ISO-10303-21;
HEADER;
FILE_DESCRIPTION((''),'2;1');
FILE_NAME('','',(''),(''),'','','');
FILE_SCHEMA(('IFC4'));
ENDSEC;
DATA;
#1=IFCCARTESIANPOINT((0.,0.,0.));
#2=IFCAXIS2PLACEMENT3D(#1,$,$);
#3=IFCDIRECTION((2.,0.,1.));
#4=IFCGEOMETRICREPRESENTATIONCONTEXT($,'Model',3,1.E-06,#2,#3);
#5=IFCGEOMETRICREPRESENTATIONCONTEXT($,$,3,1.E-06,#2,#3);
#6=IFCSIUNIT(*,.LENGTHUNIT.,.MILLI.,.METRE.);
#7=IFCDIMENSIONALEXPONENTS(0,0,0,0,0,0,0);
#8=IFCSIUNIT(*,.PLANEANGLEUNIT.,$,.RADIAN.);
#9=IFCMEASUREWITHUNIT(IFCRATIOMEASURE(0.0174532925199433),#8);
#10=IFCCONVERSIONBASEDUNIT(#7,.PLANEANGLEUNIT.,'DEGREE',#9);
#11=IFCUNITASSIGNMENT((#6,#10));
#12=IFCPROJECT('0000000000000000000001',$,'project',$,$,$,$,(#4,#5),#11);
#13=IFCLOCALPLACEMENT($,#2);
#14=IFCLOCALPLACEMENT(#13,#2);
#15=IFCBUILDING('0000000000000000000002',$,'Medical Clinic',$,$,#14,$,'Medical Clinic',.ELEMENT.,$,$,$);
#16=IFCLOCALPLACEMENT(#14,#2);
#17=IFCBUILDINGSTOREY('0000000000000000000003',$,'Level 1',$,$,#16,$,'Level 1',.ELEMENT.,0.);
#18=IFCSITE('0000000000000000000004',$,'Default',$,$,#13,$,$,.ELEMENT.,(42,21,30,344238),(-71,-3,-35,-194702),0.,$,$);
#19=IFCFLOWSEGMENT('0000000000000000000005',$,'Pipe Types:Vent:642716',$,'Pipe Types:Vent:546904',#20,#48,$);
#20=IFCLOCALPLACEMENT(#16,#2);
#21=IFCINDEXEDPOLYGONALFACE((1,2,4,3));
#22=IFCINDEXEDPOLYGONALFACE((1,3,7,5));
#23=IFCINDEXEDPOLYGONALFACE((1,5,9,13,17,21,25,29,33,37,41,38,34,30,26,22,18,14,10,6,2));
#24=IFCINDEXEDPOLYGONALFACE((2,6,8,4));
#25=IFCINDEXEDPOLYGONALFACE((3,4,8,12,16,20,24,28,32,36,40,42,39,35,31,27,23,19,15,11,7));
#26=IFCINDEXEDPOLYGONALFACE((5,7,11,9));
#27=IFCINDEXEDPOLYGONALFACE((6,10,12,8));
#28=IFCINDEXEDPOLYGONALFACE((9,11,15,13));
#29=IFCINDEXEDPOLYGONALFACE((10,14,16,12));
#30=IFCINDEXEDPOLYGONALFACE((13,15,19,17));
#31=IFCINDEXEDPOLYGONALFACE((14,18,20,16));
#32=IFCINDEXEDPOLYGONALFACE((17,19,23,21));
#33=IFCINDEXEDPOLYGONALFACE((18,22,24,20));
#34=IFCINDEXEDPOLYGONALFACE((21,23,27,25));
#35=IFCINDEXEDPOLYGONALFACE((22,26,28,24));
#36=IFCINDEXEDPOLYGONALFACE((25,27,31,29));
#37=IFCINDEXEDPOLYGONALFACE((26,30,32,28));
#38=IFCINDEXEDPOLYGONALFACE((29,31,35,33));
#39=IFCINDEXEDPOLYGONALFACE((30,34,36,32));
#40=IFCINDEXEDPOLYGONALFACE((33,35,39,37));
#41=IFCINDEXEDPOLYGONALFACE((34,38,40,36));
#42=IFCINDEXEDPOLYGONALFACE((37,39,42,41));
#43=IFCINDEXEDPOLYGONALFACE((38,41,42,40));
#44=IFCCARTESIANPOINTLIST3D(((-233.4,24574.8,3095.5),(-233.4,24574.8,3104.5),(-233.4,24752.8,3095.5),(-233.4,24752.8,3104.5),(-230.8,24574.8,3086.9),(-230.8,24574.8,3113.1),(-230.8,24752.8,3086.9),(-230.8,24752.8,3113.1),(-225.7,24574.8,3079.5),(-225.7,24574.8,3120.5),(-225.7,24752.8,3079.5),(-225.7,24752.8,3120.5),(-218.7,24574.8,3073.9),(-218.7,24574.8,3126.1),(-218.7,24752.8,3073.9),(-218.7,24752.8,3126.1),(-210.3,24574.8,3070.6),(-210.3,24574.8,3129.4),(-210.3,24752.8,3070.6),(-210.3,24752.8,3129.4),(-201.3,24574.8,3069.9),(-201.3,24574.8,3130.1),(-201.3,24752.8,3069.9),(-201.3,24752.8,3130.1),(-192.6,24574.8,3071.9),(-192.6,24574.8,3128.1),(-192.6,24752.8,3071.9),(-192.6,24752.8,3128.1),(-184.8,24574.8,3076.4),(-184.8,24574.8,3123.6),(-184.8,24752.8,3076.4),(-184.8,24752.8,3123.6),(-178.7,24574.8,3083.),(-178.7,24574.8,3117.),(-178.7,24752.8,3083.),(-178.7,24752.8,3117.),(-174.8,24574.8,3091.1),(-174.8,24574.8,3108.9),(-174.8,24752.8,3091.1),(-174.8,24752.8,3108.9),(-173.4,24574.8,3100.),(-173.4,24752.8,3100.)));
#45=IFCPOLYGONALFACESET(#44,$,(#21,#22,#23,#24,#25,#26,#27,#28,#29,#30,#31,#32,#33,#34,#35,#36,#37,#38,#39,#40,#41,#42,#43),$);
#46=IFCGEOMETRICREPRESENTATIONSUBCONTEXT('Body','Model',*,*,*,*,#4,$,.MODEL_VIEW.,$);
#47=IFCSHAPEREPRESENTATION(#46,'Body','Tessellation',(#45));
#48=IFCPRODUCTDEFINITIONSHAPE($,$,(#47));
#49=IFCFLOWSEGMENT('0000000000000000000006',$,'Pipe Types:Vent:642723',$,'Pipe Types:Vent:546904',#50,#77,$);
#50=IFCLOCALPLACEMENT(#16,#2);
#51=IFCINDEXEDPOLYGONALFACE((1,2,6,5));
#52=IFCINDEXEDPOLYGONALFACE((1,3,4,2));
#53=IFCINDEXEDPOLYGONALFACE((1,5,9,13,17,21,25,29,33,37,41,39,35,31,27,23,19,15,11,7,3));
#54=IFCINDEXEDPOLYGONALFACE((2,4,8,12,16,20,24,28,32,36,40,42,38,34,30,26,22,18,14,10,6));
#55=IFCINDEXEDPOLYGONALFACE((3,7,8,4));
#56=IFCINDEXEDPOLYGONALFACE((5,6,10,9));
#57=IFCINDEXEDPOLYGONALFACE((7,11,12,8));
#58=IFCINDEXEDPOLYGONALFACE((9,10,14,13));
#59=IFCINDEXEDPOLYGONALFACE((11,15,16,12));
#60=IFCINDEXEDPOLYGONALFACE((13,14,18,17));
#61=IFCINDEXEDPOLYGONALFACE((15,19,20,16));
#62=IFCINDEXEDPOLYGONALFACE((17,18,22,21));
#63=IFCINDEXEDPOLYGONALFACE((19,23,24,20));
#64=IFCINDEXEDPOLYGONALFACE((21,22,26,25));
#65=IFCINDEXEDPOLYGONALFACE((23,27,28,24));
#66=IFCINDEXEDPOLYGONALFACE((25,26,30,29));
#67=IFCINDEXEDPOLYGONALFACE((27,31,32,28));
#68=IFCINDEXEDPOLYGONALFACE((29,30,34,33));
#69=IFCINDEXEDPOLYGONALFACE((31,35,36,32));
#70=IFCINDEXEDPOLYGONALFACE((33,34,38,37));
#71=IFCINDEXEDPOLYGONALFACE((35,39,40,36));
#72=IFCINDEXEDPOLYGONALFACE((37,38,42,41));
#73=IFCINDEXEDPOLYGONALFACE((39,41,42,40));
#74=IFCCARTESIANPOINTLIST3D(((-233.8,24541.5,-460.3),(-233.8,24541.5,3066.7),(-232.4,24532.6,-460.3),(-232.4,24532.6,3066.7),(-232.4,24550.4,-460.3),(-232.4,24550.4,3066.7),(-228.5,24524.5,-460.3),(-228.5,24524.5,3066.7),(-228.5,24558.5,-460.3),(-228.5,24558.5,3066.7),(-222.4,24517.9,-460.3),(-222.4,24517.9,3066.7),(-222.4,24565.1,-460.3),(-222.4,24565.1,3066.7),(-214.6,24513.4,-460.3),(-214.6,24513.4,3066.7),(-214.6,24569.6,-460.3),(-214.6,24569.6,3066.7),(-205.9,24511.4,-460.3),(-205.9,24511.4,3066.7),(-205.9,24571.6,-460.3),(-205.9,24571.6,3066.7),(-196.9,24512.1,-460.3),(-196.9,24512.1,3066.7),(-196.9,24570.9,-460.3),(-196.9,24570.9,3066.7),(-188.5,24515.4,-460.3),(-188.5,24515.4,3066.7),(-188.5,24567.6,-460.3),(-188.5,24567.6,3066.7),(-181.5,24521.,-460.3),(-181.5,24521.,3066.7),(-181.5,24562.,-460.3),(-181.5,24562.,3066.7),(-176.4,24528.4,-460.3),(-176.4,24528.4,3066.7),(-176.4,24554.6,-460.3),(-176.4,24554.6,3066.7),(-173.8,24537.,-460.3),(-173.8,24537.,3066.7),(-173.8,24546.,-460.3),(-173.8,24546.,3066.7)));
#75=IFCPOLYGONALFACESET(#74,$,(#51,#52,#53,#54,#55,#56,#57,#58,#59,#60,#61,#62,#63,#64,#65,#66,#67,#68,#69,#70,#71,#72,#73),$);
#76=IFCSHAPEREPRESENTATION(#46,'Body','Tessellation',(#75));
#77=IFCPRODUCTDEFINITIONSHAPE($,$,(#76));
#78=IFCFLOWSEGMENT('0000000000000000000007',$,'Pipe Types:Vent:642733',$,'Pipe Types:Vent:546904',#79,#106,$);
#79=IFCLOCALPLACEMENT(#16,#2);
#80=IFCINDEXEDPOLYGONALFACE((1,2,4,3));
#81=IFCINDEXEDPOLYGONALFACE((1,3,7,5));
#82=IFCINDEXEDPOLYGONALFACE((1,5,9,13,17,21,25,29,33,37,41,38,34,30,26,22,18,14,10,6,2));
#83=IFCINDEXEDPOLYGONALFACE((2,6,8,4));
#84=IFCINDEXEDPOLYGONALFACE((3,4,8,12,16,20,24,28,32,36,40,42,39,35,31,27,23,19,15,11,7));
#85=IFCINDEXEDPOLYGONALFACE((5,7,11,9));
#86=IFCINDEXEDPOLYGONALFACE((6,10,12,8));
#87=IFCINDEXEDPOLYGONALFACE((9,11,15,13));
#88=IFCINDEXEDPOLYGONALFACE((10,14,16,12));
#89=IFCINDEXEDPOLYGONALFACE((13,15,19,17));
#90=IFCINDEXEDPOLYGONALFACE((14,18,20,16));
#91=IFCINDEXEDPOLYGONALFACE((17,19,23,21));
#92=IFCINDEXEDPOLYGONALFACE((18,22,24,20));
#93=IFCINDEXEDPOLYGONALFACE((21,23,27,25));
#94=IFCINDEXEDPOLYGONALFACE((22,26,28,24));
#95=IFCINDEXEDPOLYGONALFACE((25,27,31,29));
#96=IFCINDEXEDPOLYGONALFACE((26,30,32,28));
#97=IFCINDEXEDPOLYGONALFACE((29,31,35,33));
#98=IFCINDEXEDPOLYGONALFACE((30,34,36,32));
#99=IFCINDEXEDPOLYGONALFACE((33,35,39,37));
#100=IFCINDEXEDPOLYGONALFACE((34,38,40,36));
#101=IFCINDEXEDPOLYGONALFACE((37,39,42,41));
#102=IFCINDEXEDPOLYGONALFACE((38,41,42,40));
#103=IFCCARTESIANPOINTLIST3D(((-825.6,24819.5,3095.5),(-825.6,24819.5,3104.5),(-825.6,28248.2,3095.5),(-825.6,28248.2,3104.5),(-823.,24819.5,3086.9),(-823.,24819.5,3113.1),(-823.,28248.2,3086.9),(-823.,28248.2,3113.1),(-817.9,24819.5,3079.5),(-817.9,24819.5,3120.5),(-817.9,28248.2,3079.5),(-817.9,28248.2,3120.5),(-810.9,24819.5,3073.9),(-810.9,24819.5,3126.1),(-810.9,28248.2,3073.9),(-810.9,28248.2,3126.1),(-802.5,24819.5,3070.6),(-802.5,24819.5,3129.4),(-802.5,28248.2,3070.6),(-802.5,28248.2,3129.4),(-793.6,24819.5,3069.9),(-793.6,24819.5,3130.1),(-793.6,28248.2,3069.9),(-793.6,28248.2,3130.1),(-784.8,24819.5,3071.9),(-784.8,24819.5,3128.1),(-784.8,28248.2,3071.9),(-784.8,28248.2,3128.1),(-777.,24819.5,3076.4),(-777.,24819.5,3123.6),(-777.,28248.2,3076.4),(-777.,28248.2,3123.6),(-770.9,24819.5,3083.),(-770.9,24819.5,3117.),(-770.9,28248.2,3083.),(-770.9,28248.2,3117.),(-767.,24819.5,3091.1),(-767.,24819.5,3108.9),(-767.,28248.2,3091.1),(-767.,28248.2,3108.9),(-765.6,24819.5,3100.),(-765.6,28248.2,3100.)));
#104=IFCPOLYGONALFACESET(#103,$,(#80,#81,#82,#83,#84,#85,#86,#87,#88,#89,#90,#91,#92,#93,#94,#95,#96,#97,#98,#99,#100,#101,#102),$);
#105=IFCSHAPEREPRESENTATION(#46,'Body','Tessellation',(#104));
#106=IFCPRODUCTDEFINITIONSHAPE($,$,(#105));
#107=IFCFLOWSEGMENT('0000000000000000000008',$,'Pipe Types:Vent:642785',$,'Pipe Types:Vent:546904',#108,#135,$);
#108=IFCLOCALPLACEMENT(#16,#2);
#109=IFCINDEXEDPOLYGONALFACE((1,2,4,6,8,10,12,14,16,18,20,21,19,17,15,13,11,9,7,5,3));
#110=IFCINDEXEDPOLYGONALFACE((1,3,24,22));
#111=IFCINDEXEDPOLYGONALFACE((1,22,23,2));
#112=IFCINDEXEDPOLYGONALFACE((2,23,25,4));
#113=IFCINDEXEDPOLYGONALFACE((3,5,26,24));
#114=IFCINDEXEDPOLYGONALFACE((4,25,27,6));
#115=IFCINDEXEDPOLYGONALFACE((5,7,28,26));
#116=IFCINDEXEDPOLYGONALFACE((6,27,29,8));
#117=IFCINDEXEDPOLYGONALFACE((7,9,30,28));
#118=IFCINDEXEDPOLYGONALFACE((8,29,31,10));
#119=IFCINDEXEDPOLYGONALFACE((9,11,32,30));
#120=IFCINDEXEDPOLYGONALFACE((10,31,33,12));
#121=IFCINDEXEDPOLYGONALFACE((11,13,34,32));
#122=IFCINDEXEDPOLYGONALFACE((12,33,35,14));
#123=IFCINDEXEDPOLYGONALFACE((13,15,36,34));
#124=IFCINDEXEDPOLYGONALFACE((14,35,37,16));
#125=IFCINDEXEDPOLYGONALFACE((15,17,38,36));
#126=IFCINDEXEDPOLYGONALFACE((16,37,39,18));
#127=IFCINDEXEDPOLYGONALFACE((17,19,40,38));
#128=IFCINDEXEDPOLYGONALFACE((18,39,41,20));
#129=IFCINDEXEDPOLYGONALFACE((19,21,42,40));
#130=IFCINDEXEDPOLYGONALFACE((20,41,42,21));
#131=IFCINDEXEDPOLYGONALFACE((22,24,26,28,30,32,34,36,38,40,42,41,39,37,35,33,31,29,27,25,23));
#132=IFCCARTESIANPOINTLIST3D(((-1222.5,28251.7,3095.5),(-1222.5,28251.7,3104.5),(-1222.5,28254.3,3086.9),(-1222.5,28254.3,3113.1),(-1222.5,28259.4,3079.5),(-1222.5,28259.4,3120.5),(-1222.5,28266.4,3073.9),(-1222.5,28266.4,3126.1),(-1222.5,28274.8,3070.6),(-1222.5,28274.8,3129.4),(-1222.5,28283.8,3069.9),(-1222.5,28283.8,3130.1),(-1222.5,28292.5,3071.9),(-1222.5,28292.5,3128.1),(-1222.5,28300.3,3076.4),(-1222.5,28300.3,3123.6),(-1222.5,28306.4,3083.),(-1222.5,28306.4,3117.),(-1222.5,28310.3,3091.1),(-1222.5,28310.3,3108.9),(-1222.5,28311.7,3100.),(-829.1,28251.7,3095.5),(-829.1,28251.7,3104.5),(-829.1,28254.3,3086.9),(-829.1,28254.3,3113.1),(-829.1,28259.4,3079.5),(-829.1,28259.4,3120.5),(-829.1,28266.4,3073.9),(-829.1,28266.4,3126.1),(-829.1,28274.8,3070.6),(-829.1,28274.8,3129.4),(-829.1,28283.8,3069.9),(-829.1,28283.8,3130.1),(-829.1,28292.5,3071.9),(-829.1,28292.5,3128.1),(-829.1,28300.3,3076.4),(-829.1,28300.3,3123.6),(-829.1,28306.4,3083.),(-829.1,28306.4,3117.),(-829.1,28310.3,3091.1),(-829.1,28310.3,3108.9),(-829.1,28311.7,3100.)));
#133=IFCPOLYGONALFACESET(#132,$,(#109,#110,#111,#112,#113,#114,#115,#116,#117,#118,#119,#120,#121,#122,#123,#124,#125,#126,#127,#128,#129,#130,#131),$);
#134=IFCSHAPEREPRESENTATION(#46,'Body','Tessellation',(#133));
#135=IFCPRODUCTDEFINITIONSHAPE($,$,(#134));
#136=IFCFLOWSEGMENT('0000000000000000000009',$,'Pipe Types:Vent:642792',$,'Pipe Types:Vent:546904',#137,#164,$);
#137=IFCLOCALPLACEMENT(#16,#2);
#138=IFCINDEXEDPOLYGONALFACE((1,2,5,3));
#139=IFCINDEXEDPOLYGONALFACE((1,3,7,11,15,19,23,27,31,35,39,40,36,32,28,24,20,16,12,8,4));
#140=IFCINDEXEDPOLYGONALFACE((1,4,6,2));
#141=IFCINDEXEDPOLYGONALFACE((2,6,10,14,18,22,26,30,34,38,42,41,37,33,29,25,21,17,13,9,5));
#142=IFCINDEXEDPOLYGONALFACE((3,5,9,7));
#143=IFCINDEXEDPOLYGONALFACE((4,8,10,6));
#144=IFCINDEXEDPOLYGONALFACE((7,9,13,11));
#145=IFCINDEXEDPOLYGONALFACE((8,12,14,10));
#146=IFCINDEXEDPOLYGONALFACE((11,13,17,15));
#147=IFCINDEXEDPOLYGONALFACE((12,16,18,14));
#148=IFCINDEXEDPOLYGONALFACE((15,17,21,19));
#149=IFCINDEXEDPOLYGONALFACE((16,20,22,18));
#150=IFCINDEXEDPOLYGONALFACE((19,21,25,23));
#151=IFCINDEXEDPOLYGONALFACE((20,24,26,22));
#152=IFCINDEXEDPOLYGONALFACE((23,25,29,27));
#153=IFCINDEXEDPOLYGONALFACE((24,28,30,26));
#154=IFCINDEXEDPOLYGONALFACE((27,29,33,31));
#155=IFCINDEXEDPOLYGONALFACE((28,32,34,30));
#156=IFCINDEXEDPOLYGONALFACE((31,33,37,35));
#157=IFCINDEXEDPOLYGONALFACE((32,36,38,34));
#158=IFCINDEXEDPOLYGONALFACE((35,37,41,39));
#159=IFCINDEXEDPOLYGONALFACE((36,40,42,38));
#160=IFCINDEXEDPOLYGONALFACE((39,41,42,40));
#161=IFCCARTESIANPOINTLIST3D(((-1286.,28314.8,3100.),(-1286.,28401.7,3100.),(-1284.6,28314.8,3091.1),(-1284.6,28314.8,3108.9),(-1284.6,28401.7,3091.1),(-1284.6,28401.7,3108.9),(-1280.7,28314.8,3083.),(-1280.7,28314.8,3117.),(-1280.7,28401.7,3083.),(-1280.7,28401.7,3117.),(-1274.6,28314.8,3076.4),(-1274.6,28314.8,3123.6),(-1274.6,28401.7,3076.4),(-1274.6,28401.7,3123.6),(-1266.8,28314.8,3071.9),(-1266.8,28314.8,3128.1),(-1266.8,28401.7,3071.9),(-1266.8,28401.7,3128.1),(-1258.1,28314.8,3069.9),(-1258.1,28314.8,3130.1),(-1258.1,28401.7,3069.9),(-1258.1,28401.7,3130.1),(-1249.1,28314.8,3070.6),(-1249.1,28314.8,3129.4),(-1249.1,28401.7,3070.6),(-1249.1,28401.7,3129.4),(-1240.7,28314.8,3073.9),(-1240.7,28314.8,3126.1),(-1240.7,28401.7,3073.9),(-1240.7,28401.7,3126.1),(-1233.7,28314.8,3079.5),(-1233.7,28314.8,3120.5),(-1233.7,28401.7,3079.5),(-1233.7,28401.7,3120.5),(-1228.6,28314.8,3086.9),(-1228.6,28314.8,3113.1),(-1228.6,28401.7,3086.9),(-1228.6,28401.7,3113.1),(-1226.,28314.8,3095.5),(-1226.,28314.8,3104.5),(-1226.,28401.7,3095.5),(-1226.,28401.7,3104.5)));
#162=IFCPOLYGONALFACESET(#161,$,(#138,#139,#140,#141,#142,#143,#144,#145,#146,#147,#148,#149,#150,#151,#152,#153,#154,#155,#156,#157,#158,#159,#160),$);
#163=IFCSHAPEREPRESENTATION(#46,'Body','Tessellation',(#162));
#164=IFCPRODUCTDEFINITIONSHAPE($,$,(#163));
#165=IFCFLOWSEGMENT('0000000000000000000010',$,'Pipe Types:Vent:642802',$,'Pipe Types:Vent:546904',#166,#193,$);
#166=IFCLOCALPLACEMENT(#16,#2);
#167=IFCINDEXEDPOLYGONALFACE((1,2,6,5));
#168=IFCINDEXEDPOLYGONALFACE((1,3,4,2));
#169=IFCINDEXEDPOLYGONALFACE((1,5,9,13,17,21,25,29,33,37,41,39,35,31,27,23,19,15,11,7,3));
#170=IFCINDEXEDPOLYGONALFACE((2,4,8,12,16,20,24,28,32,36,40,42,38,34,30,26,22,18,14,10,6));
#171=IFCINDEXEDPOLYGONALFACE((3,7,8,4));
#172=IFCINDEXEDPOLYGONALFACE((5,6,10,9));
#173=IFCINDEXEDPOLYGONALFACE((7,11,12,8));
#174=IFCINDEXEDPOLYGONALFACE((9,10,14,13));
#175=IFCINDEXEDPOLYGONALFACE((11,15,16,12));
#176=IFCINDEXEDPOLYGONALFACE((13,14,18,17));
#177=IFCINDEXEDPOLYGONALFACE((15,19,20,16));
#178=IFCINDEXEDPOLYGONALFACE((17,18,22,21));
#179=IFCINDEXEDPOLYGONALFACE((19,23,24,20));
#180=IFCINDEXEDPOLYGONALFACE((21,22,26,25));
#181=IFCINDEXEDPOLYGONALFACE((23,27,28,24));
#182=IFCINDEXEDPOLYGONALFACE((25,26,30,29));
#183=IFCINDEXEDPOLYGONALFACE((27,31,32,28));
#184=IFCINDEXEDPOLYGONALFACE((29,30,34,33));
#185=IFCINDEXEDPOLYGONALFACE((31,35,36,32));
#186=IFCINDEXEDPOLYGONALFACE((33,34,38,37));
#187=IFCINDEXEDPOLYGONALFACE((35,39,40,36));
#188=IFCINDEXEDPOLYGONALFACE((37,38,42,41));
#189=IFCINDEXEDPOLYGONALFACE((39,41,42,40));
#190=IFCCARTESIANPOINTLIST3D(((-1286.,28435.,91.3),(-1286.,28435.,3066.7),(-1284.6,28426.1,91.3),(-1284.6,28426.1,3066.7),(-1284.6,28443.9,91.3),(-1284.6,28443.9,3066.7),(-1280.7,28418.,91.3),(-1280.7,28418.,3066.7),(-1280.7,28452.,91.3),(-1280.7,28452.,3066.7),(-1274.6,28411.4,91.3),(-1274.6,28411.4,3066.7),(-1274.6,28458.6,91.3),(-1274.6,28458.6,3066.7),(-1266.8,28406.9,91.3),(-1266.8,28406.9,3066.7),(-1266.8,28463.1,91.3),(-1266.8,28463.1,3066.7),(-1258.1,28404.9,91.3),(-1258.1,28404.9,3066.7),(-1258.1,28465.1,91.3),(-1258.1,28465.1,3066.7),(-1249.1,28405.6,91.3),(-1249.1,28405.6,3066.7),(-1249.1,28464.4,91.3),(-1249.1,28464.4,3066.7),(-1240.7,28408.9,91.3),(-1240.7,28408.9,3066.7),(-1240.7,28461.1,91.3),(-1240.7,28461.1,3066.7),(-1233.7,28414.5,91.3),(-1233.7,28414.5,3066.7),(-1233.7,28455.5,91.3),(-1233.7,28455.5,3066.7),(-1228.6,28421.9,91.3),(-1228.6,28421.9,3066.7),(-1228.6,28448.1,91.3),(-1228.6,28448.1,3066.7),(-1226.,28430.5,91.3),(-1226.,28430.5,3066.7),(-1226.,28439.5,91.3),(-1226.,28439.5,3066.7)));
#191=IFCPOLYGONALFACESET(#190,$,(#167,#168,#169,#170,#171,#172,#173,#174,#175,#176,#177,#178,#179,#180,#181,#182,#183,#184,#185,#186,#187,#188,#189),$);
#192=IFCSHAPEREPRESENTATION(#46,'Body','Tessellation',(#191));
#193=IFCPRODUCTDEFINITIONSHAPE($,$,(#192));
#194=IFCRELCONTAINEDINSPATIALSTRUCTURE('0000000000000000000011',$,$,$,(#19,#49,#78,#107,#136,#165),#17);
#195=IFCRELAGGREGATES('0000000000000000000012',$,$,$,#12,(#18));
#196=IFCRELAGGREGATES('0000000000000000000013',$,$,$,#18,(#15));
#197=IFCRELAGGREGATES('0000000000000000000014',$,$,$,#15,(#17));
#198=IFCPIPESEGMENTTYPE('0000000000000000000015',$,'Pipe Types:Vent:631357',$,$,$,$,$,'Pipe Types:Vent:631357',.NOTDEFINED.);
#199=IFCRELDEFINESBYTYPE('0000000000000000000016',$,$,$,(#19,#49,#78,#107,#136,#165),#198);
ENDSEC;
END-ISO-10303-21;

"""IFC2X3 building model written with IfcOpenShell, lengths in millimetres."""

from ifc_helpers import new_model, entity, si_unit, converted_unit, direction, frame, frame_2d, origin, place, context, subcontext, project, spatial, circle, extrude, type_object, element, save


model = new_model("IFC2X3")

# Units and contexts
model_context = context("Model", 3, precision=1e-06, world=origin(), true_north=direction((2.0, 0.0, 1.0)))
context_of_model = context(None, 3, precision=1e-06, world=origin(), true_north=direction((2.0, 0.0, 1.0)))
body_context = subcontext(model_context, "Body", "Model", "MODEL_VIEW")
ifc_project = project(units=[si_unit("LENGTHUNIT", "METRE", prefix="MILLI"), converted_unit("PLANEANGLEUNIT", "DEGREE", entity("IfcRatioMeasure", 0.0174532925199433), si_unit("PLANEANGLEUNIT", "RADIAN"), dimensions=[0, 0, 0, 0, 0, 0, 0])], contexts=[model_context, context_of_model])

# Site, building, storey
site_placement = place(None, origin())
site = spatial("IfcSite", under=ifc_project, at=site_placement, Name="Default", CompositionType="ELEMENT", RefLatitude=(42, 21, 30, 344238), RefLongitude=(-71, -3, -35, -194702), RefElevation=0.0)
building_placement = place(site_placement, origin())
building = spatial("IfcBuilding", under=site, at=building_placement, Name="Medical Clinic", LongName="Medical Clinic", CompositionType="ELEMENT")
storey_placement = place(building_placement, origin())
storey = spatial("IfcBuildingStorey", under=building, at=storey_placement, Name="Level 1", LongName="Level 1", CompositionType="ELEMENT", Elevation=0.0)

# Flow segments
pipe_segment_type_1 = type_object("IfcPipeSegmentType", Name="Pipe Types:Vent:631357", ElementType="Pipe Types:Vent:631357", PredefinedType="NOTDEFINED")
flow_segment_1_placement = place(storey_placement, origin())
element("IfcFlowSegment", 1, at=flow_segment_1_placement, inside=storey, type_object=pipe_segment_type_1, Name="Pipe Types:Vent:642716", ObjectType="Pipe Types:Vent:546904", context=body_context, shape_type="SweptSolid", body=[
    extrude(circle(Radius=30.2, at=frame_2d((0.0, 0.0), x_axis=(1.0, 0.0))), frame((-203.6, 24574.8, 3100.0), z_axis=(0.0, 1.0, 0.0), x_axis=(1.0, 0.0, 0.0)), (0.0, 0.0, 1.0), 178.0),
])
flow_segment_2_placement = place(storey_placement, origin())
element("IfcFlowSegment", 2, at=flow_segment_2_placement, inside=storey, type_object=pipe_segment_type_1, Name="Pipe Types:Vent:642723", ObjectType="Pipe Types:Vent:546904", context=body_context, shape_type="SweptSolid", body=[
    extrude(circle(Radius=30.2, at=frame_2d((0.0, 0.0), x_axis=(1.0, 0.0))), frame((-203.6, 24541.5, -460.3), z_axis=(0.0, 0.0, 1.0), x_axis=(-1.0, 0.0, 0.0)), (0.0, 0.0, 1.0), 3527.0),
])
flow_segment_3_placement = place(storey_placement, origin())
element("IfcFlowSegment", 3, at=flow_segment_3_placement, inside=storey, type_object=pipe_segment_type_1, Name="Pipe Types:Vent:642733", ObjectType="Pipe Types:Vent:546904", context=body_context, shape_type="SweptSolid", body=[
    extrude(circle(Radius=30.2, at=frame_2d((0.0, 0.0), x_axis=(1.0, 0.0))), frame((-795.8, 24819.5, 3100.0), z_axis=(0.0, 1.0, 0.0), x_axis=(1.0, 0.0, 0.0)), (0.0, 0.0, 1.0), 3428.7),
])
flow_segment_4_placement = place(storey_placement, origin())
element("IfcFlowSegment", 4, at=flow_segment_4_placement, inside=storey, type_object=pipe_segment_type_1, Name="Pipe Types:Vent:642785", ObjectType="Pipe Types:Vent:546904", context=body_context, shape_type="SweptSolid", body=[
    extrude(circle(Radius=30.2, at=frame_2d((0.0, 0.0), x_axis=(1.0, 0.0))), frame((-1222.5, 28281.5, 3100.0), z_axis=(1.0, 0.0, 0.0), x_axis=(0.0, 1.0, 0.0)), (0.0, 0.0, 1.0), 393.3),
])
flow_segment_5_placement = place(storey_placement, origin())
element("IfcFlowSegment", 5, at=flow_segment_5_placement, inside=storey, type_object=pipe_segment_type_1, Name="Pipe Types:Vent:642792", ObjectType="Pipe Types:Vent:546904", context=body_context, shape_type="SweptSolid", body=[
    extrude(circle(Radius=30.2, at=frame_2d((0.0, 0.0), x_axis=(1.0, 0.0))), frame((-1255.8, 28314.8, 3100.0), z_axis=(0.0, 1.0, 0.0), x_axis=(-1.0, 0.0, 0.0)), (0.0, 0.0, 1.0), 86.8),
])
flow_segment_6_placement = place(storey_placement, origin())
element("IfcFlowSegment", 6, at=flow_segment_6_placement, inside=storey, type_object=pipe_segment_type_1, Name="Pipe Types:Vent:642802", ObjectType="Pipe Types:Vent:546904", context=body_context, shape_type="SweptSolid", body=[
    extrude(circle(Radius=30.2, at=frame_2d((0.0, 0.0), x_axis=(1.0, 0.0))), frame((-1255.8, 28435.0, 91.3), z_axis=(0.0, 0.0, 1.0), x_axis=(-1.0, 0.0, 0.0)), (0.0, 0.0, 1.0), 2975.4),
])

save(model, "model.ifc")
